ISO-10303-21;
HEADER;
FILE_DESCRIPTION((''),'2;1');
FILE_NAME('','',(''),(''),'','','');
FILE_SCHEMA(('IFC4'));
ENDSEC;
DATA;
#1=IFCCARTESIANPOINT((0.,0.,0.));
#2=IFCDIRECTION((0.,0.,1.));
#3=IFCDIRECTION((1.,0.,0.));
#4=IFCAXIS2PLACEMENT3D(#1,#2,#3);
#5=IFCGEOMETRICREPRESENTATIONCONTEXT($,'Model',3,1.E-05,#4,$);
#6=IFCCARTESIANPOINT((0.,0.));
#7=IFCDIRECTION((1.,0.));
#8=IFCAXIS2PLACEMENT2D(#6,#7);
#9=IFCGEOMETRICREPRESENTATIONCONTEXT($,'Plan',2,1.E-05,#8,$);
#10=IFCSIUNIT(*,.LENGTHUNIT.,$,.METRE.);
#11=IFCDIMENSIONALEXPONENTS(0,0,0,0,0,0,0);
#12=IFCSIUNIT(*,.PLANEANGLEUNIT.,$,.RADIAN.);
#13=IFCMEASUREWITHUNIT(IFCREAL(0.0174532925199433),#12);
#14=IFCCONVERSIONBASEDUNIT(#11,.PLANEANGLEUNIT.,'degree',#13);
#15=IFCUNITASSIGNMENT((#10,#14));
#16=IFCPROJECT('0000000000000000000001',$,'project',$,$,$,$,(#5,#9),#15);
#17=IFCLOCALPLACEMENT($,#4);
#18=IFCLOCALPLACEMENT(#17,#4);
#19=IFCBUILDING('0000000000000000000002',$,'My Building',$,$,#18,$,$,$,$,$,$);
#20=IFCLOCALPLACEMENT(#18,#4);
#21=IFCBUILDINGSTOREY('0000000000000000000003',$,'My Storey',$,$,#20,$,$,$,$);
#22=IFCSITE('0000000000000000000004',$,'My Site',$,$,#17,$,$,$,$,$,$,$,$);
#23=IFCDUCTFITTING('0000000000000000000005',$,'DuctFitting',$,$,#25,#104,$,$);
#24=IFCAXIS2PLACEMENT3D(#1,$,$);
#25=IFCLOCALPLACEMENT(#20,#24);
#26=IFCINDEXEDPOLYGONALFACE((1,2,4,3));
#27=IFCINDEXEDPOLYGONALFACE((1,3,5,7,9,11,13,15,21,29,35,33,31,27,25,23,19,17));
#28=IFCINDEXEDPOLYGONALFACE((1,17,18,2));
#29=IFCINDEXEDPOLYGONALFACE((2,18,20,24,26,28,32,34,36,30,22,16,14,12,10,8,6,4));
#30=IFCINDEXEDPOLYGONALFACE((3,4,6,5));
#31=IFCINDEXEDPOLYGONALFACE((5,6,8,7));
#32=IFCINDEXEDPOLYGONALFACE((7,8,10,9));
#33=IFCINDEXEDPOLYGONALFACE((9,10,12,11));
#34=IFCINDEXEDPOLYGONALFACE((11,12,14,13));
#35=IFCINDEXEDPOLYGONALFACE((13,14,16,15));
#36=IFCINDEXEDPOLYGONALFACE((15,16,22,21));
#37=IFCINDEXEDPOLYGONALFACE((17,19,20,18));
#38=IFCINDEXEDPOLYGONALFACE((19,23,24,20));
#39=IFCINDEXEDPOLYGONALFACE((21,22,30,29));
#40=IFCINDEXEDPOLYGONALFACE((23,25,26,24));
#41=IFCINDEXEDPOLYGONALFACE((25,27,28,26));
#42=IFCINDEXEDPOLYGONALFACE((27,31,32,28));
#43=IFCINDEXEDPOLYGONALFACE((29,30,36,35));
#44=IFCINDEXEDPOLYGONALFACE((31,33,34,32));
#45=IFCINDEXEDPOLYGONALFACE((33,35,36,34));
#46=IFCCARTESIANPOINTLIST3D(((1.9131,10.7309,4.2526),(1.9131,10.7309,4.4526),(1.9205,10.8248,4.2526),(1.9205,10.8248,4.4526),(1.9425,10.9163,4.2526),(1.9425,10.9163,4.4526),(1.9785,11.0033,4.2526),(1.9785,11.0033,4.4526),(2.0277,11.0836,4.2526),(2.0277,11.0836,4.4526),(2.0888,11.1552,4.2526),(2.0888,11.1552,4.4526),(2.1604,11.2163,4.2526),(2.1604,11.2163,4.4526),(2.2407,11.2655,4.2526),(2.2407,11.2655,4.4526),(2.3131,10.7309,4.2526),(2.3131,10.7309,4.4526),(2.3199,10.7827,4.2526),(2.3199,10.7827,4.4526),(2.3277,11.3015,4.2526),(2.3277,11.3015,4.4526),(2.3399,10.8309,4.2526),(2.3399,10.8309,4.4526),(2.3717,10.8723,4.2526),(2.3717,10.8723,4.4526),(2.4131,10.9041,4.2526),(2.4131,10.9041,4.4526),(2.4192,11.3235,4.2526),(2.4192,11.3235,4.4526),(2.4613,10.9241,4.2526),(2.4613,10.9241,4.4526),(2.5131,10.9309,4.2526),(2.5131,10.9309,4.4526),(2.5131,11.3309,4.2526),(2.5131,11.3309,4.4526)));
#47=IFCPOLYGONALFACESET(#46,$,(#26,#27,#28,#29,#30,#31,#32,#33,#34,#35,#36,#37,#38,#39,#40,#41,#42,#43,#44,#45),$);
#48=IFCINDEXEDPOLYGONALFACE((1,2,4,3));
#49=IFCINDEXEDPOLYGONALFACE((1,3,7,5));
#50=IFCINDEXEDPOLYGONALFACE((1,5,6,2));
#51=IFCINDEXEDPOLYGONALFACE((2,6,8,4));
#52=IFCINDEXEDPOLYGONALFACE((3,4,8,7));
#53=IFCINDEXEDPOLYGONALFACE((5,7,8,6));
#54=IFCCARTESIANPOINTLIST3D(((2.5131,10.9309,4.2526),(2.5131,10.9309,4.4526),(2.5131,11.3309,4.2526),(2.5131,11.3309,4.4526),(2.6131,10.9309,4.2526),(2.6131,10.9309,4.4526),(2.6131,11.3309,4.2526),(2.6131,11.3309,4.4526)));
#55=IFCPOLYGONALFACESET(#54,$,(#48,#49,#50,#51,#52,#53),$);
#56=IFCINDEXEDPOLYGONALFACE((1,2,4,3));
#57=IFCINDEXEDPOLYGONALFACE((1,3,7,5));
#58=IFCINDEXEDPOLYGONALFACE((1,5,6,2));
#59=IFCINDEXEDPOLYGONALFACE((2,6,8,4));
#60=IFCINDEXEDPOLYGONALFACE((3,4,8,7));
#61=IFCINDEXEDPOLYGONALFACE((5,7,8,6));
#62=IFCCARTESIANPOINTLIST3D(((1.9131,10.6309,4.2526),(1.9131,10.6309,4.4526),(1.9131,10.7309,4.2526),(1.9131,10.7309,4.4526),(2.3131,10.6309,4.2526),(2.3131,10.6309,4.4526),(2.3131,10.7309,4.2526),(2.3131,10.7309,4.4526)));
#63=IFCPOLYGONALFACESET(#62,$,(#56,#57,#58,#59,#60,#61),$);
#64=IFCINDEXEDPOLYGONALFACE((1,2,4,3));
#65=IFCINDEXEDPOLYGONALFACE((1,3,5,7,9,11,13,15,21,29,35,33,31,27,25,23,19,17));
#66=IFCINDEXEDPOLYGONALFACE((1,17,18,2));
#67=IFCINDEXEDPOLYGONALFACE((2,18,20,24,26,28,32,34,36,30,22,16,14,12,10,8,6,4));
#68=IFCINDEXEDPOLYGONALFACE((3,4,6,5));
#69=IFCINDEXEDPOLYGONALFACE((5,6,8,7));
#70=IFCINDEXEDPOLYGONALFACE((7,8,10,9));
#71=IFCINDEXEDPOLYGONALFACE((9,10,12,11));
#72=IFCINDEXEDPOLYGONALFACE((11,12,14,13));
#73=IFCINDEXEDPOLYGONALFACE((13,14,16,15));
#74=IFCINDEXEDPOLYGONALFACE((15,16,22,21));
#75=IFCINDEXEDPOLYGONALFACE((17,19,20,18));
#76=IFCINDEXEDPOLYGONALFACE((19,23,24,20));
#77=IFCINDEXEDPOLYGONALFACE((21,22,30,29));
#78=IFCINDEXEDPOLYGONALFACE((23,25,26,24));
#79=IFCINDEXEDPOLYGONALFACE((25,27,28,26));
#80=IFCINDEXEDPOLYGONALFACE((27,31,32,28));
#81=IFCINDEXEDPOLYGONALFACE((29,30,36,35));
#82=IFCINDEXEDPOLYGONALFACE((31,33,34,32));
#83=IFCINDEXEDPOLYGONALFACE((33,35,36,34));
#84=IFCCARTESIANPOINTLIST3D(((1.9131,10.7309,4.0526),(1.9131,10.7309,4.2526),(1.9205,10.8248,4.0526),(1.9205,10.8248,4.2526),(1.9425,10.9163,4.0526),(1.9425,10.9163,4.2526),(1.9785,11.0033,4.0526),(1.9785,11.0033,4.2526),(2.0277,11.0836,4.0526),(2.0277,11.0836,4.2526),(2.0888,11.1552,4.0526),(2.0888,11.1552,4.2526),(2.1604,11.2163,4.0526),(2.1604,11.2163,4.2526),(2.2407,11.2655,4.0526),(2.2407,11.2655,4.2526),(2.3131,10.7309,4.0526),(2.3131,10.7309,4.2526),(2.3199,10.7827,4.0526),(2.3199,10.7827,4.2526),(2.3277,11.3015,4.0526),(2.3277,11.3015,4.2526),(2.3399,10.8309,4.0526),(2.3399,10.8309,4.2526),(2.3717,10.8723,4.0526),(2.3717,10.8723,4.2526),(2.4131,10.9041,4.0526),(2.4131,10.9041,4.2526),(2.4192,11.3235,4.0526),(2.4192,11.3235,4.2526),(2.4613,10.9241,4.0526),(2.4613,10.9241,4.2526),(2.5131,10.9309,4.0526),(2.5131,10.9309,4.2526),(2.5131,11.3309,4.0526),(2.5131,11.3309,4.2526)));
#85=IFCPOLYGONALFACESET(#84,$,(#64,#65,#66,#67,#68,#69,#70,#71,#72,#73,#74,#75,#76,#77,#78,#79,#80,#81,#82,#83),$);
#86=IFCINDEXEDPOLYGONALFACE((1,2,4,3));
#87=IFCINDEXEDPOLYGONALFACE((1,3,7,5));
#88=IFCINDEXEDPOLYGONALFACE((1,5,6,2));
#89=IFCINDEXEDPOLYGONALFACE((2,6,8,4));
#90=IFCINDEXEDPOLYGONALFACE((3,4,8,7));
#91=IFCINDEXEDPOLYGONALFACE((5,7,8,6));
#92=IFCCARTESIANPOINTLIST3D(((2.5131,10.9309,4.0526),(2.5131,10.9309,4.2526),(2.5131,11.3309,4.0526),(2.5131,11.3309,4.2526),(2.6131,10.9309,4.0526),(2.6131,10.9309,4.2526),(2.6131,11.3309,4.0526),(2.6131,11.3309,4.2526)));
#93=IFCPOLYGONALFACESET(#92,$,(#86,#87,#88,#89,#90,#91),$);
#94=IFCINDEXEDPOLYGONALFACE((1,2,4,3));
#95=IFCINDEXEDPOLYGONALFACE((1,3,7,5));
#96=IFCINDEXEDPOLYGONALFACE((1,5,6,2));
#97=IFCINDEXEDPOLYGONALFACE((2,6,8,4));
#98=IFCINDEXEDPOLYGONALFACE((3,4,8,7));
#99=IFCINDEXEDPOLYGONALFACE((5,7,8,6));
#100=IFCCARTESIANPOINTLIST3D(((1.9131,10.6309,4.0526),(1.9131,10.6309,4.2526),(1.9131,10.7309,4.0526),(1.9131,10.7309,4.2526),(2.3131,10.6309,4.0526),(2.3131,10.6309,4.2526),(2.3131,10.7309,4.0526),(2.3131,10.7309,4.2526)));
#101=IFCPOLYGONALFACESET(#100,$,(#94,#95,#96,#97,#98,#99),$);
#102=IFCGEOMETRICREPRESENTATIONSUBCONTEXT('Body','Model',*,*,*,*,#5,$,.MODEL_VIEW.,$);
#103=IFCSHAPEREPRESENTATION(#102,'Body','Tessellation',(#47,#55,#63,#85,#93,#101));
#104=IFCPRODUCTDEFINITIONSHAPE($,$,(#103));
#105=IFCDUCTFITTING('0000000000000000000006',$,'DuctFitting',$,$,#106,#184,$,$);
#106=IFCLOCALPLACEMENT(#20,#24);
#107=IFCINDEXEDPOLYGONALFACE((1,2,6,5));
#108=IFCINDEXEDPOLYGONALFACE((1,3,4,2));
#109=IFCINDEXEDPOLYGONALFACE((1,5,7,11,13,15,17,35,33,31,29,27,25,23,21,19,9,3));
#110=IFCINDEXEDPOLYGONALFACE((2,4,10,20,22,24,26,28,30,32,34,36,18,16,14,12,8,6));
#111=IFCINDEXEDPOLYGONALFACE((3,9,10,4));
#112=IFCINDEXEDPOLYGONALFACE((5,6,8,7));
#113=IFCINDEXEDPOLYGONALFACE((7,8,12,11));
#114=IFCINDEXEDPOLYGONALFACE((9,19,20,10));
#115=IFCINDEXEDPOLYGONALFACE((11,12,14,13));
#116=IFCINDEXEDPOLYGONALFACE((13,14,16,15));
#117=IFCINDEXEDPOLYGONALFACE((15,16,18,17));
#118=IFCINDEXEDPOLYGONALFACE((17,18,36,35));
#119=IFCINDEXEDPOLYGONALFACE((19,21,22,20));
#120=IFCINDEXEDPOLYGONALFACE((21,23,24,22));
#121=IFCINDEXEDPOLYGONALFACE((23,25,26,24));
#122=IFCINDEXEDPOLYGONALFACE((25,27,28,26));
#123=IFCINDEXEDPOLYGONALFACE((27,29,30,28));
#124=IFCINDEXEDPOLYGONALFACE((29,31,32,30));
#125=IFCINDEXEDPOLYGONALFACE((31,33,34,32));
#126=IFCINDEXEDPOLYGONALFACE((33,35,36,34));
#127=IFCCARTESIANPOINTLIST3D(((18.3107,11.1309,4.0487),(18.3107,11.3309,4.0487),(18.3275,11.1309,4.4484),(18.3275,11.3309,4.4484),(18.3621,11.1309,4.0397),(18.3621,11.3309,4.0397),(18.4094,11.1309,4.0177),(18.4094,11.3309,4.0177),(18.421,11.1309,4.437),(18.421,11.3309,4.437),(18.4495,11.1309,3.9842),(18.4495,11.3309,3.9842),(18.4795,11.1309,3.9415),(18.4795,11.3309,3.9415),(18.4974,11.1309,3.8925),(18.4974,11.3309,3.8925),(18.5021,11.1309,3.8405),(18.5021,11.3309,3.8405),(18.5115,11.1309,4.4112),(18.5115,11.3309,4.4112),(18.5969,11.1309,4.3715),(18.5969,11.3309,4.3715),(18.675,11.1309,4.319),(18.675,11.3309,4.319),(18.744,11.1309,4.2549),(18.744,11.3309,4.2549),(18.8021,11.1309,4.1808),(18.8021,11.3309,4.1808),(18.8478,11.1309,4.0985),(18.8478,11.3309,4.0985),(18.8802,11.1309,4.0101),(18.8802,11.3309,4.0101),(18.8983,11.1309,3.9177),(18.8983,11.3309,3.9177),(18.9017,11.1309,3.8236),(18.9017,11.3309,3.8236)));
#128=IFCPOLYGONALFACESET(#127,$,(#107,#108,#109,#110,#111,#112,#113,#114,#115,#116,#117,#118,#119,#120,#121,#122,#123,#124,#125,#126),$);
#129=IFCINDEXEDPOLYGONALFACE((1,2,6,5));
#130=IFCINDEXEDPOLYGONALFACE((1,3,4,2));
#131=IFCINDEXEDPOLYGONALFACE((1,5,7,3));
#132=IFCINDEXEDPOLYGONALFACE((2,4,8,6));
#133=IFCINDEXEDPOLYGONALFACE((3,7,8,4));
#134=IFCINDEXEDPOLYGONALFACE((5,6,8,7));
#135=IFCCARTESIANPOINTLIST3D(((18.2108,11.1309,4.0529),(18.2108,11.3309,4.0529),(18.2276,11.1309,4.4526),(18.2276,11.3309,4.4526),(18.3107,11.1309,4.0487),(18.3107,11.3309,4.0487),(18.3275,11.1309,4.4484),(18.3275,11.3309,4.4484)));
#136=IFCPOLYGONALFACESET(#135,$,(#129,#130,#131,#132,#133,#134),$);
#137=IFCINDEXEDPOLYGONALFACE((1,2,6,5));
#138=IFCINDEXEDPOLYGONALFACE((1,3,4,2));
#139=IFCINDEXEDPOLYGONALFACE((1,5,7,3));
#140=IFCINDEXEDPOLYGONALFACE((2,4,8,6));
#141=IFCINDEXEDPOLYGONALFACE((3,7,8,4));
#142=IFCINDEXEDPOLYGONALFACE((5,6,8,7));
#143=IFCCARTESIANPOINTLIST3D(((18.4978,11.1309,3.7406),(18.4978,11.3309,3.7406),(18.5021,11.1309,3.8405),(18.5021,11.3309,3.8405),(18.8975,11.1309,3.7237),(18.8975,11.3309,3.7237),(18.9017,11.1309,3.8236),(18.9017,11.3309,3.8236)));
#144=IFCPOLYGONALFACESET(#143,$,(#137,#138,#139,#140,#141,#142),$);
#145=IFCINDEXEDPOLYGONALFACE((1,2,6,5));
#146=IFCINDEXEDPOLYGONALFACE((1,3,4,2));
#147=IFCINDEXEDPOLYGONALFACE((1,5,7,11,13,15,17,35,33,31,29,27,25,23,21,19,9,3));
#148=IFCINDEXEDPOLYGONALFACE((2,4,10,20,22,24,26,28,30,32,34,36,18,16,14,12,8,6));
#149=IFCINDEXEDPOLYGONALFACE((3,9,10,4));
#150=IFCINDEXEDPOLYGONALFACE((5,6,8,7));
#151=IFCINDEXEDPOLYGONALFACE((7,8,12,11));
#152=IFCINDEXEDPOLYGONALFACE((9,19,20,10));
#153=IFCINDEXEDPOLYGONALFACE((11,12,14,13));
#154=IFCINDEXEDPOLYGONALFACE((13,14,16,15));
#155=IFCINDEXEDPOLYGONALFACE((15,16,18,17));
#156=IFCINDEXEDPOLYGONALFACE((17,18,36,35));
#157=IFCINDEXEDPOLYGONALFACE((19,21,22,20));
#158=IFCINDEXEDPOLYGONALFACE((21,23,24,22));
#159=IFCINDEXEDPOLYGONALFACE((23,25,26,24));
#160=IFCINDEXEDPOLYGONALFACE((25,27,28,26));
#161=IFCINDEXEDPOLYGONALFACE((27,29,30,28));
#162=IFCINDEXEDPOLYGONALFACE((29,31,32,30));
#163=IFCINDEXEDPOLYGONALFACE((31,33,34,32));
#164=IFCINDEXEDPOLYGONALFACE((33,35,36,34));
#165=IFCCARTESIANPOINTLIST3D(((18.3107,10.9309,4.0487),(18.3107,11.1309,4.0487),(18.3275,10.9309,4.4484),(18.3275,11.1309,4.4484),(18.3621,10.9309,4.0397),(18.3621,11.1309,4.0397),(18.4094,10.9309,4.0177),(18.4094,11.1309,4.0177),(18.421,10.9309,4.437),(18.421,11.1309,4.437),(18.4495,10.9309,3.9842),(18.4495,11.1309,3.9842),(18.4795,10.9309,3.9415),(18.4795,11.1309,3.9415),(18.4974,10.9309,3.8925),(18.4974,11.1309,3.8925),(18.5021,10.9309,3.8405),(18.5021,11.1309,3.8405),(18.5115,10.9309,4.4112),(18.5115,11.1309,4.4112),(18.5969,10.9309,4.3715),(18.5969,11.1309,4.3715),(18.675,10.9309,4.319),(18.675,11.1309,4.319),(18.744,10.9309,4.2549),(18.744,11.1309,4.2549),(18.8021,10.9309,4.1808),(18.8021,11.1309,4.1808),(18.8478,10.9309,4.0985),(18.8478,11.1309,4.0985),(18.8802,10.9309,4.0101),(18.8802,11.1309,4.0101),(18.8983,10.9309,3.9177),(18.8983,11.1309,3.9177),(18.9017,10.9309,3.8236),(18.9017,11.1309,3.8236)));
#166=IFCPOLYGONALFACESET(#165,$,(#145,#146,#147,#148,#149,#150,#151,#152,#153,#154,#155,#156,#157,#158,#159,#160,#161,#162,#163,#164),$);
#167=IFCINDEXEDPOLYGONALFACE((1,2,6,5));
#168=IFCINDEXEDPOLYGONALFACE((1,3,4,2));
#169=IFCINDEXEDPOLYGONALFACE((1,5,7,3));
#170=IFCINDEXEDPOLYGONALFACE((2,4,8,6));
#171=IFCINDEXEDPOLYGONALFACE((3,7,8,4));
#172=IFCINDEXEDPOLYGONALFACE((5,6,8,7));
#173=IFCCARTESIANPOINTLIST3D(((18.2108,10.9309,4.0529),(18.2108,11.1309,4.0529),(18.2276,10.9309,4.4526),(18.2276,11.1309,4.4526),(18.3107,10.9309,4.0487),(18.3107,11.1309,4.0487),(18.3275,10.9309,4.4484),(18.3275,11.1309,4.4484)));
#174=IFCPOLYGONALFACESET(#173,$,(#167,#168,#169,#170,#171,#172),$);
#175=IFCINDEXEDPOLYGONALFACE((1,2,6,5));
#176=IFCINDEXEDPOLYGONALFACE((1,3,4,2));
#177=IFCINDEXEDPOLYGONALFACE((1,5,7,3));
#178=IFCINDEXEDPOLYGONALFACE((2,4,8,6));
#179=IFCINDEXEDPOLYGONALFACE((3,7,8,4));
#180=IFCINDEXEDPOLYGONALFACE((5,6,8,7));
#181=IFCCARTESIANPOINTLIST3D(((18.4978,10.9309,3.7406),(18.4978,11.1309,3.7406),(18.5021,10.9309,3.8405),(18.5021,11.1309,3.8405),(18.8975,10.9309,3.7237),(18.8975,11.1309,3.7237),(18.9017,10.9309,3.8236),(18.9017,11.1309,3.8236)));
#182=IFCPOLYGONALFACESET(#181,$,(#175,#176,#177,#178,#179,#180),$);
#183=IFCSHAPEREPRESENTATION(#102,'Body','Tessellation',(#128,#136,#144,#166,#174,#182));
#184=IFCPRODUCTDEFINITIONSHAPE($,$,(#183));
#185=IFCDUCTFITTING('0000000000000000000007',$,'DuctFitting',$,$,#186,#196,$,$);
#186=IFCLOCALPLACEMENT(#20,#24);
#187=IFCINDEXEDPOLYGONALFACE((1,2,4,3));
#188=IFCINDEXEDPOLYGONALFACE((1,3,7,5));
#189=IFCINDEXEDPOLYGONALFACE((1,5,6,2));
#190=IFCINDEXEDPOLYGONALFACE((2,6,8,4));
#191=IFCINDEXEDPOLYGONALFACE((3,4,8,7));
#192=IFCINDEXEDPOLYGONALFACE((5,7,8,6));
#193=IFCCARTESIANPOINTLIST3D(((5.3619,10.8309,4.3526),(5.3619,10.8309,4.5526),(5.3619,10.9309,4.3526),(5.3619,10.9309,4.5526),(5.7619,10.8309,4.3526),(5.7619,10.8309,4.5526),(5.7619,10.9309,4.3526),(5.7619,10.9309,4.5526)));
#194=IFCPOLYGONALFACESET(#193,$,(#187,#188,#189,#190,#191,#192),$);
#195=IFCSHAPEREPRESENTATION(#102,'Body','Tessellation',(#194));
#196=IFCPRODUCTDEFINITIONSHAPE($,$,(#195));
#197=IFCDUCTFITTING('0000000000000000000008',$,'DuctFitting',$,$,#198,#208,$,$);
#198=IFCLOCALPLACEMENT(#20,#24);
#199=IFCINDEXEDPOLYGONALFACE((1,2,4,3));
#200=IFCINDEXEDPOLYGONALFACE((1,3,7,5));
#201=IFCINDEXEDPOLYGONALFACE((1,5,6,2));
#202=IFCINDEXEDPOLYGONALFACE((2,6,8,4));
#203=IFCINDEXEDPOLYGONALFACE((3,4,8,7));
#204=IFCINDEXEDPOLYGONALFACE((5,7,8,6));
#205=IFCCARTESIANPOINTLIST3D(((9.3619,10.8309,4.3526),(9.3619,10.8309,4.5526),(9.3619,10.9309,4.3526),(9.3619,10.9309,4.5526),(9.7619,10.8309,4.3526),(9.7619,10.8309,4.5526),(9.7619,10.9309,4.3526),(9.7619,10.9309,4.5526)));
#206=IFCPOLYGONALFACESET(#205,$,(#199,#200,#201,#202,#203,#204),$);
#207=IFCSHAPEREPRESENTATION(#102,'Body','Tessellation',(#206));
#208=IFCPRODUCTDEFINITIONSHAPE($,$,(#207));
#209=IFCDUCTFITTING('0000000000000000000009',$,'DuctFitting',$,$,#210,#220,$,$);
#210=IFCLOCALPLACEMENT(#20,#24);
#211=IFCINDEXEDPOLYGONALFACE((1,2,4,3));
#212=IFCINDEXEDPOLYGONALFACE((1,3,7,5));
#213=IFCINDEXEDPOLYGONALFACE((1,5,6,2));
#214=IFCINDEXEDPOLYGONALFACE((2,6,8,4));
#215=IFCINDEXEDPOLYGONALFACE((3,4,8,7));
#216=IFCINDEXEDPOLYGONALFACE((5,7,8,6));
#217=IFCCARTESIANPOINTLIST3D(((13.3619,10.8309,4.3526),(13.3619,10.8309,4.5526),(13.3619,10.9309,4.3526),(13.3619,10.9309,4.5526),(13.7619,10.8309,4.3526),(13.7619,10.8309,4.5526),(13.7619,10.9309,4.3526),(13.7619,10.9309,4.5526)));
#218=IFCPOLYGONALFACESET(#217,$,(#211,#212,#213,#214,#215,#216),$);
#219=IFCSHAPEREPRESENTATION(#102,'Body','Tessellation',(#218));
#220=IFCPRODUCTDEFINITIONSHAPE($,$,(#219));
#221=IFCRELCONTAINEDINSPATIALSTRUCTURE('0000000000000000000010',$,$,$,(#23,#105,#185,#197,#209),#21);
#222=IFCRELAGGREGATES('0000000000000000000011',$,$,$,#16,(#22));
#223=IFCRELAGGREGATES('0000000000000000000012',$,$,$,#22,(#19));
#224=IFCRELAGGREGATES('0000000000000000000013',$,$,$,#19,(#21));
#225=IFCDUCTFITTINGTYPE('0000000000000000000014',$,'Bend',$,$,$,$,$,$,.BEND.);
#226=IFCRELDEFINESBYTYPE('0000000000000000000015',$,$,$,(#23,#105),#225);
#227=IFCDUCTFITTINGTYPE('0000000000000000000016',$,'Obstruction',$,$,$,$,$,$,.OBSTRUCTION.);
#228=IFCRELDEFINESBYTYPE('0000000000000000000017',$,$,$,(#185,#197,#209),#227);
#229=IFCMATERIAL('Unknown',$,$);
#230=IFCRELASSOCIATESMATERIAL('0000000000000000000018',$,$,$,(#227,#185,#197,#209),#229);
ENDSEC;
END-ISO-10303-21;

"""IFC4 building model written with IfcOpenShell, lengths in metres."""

from ifc_helpers import new_model, entity, si_unit, converted_unit, frame, origin_with_axes, origin_2d_with_axis, place, context, subcontext, project, spatial, line, arc, indexed_curve, rectangle, outline, extrude, source, transform, mapped, material, material_profile, profile_set, profile_usage, type_object, type_shapes, element, save


model = new_model("IFC4")

# Units and contexts
model_context = context("Model", 3, precision=1e-05, world=origin_with_axes())
plan_context = context("Plan", 2, precision=1e-05, world=origin_2d_with_axis())
body_context_1 = subcontext(model_context, "Body", "Model", "MODEL_VIEW")
ifc_project = project(units=[si_unit("LENGTHUNIT", "METRE"), converted_unit("PLANEANGLEUNIT", "degree", entity("IfcReal", 0.0174532925199433), si_unit("PLANEANGLEUNIT", "RADIAN"), dimensions=[0, 0, 0, 0, 0, 0, 0])], contexts=[model_context, plan_context])

# Site, building, storey
site_placement = place(None, origin_with_axes())
site = spatial("IfcSite", under=ifc_project, at=site_placement, Name="My Site")
building_placement = place(site_placement, origin_with_axes())
building = spatial("IfcBuilding", under=site, at=building_placement, Name="My Building")
storey_placement = place(building_placement, origin_with_axes())
storey = spatial("IfcBuildingStorey", under=building, at=storey_placement, Name="My Storey")

# Shared definitions
ifc_material = material(Name="Unknown")

# Duct fittings
duct_fitting_type_1 = type_object("IfcDuctFittingType", Name="Bend", PredefinedType="BEND")
shared_shape_1 = source(origin_with_axes(), body_context_1, "Body", "SweptSolid", [
    extrude(outline(indexed_curve([(0.2, 0.0), (0.2586, 0.1414), (0.4, 0.2), (0.4, 0.6), (-0.0243, 0.4243), (-0.2, 0.0)], segments=[arc(1, 2, 3), line(3, 4), arc(4, 5, 6), line(6, 1)])), frame((0.0, -0.1, 0.1), z_axis=(0.0, -1.0, 0.0), x_axis=(1.0, 0.0, 0.0)), (0.0, 0.0, -1.0), 0.2),
    extrude(rectangle(XDim=0.4, YDim=0.2), origin_with_axes(), (0.0, 0.0, 1.0), 0.1),
    extrude(rectangle(XDim=0.4, YDim=0.2), frame((0.4, 0.0, 0.5), z_axis=(1.0, 0.0, 0.0), x_axis=(0.0, 0.0, 1.0)), (0.0, 0.0, 1.0), 0.1),
    extrude(outline(indexed_curve([(0.2, 0.0), (0.2586, 0.1414), (0.4, 0.2), (0.4, 0.6), (-0.0243, 0.4243), (-0.2, 0.0)], segments=[arc(1, 2, 3), line(3, 4), arc(4, 5, 6), line(6, 1)])), frame((0.0, -0.3, 0.1), z_axis=(0.0, -1.0, 0.0), x_axis=(1.0, 0.0, 0.0)), (0.0, 0.0, -1.0), 0.2),
    extrude(rectangle(XDim=0.4, YDim=0.2), frame((0.0, -0.2, 0.0), z_axis=(0.0, 0.0, 1.0), x_axis=(1.0, 0.0, 0.0)), (0.0, 0.0, 1.0), 0.1),
    extrude(rectangle(XDim=0.4, YDim=0.2), frame((0.4, -0.2, 0.5), z_axis=(1.0, 0.0, 0.0), x_axis=(0.0, 0.0, 1.0)), (0.0, 0.0, 1.0), 0.1),
])
type_shapes(duct_fitting_type_1, [shared_shape_1])
for number, where, z_axis, x_axis, name in (
    (1, (2.6131, 11.1309, 4.3526), (-1.0, 0.0, 0.0), (0.0, -1.0, 0.0), "DuctFitting"),
    (2, (18.2192, 11.2309, 4.2527), (0.999112, 0.0, -0.042141), (-0.042141, 0.0, -0.999112), "DuctFitting"),
):
    element("IfcDuctFitting", number, at=place(storey_placement, frame(where, z_axis=z_axis, x_axis=x_axis)), inside=storey, type_object=duct_fitting_type_1, Name=name, context=body_context_1, shape_type="MappedRepresentation", body=[
        mapped(shared_shape_1, transform((0.0, 0.0, 0.0), x_axis=(1.0, 0.0, 0.0), y_axis=(0.0, 1.0, 0.0), z_axis=(0.0, 0.0, 1.0), scale=1.0)),
    ])
ifc_material_profile_1 = material_profile(ifc_material, rectangle(XDim=0.4, YDim=0.2))
ifc_profile_set_1 = profile_set([ifc_material_profile_1])
ifc_profile_usage_1 = profile_usage(ifc_profile_set_1, cardinal=5)
duct_fitting_type_2 = type_object("IfcDuctFittingType", Name="Obstruction", PredefinedType="OBSTRUCTION", material=ifc_profile_set_1)
duct_fitting_1_placement = place(storey_placement, frame((5.5619, 10.9309, 4.4526), z_axis=(0.0, -1.0, 0.0), x_axis=(1.0, 0.0, 0.0)))
element("IfcDuctFitting", 3, at=duct_fitting_1_placement, inside=storey, type_object=duct_fitting_type_2, material=ifc_profile_usage_1, Name="DuctFitting", context=body_context_1, shape_type="SweptSolid", body=[
    extrude(rectangle(XDim=0.4, YDim=0.2), origin_with_axes(), (0.0, 0.0, 1.0), 0.1),
])
ifc_profile_usage_2 = profile_usage(ifc_profile_set_1, cardinal=5)
duct_fitting_2_placement = place(storey_placement, frame((9.5619, 10.9309, 4.4526), z_axis=(0.0, -1.0, 0.0), x_axis=(1.0, 0.0, 0.0)))
element("IfcDuctFitting", 4, at=duct_fitting_2_placement, inside=storey, type_object=duct_fitting_type_2, material=ifc_profile_usage_2, Name="DuctFitting", context=body_context_1, shape_type="SweptSolid", body=[
    extrude(rectangle(XDim=0.4, YDim=0.2), origin_with_axes(), (0.0, 0.0, 1.0), 0.1),
])
ifc_profile_usage_3 = profile_usage(ifc_profile_set_1, cardinal=5)
duct_fitting_3_placement = place(storey_placement, frame((13.5619, 10.9309, 4.4526), z_axis=(0.0, -1.0, 0.0), x_axis=(1.0, 0.0, 0.0)))
element("IfcDuctFitting", 5, at=duct_fitting_3_placement, inside=storey, type_object=duct_fitting_type_2, material=ifc_profile_usage_3, Name="DuctFitting", context=body_context_1, shape_type="SweptSolid", body=[
    extrude(rectangle(XDim=0.4, YDim=0.2), origin_with_axes(), (0.0, 0.0, 1.0), 0.1),
])

save(model, "model.ifc")
